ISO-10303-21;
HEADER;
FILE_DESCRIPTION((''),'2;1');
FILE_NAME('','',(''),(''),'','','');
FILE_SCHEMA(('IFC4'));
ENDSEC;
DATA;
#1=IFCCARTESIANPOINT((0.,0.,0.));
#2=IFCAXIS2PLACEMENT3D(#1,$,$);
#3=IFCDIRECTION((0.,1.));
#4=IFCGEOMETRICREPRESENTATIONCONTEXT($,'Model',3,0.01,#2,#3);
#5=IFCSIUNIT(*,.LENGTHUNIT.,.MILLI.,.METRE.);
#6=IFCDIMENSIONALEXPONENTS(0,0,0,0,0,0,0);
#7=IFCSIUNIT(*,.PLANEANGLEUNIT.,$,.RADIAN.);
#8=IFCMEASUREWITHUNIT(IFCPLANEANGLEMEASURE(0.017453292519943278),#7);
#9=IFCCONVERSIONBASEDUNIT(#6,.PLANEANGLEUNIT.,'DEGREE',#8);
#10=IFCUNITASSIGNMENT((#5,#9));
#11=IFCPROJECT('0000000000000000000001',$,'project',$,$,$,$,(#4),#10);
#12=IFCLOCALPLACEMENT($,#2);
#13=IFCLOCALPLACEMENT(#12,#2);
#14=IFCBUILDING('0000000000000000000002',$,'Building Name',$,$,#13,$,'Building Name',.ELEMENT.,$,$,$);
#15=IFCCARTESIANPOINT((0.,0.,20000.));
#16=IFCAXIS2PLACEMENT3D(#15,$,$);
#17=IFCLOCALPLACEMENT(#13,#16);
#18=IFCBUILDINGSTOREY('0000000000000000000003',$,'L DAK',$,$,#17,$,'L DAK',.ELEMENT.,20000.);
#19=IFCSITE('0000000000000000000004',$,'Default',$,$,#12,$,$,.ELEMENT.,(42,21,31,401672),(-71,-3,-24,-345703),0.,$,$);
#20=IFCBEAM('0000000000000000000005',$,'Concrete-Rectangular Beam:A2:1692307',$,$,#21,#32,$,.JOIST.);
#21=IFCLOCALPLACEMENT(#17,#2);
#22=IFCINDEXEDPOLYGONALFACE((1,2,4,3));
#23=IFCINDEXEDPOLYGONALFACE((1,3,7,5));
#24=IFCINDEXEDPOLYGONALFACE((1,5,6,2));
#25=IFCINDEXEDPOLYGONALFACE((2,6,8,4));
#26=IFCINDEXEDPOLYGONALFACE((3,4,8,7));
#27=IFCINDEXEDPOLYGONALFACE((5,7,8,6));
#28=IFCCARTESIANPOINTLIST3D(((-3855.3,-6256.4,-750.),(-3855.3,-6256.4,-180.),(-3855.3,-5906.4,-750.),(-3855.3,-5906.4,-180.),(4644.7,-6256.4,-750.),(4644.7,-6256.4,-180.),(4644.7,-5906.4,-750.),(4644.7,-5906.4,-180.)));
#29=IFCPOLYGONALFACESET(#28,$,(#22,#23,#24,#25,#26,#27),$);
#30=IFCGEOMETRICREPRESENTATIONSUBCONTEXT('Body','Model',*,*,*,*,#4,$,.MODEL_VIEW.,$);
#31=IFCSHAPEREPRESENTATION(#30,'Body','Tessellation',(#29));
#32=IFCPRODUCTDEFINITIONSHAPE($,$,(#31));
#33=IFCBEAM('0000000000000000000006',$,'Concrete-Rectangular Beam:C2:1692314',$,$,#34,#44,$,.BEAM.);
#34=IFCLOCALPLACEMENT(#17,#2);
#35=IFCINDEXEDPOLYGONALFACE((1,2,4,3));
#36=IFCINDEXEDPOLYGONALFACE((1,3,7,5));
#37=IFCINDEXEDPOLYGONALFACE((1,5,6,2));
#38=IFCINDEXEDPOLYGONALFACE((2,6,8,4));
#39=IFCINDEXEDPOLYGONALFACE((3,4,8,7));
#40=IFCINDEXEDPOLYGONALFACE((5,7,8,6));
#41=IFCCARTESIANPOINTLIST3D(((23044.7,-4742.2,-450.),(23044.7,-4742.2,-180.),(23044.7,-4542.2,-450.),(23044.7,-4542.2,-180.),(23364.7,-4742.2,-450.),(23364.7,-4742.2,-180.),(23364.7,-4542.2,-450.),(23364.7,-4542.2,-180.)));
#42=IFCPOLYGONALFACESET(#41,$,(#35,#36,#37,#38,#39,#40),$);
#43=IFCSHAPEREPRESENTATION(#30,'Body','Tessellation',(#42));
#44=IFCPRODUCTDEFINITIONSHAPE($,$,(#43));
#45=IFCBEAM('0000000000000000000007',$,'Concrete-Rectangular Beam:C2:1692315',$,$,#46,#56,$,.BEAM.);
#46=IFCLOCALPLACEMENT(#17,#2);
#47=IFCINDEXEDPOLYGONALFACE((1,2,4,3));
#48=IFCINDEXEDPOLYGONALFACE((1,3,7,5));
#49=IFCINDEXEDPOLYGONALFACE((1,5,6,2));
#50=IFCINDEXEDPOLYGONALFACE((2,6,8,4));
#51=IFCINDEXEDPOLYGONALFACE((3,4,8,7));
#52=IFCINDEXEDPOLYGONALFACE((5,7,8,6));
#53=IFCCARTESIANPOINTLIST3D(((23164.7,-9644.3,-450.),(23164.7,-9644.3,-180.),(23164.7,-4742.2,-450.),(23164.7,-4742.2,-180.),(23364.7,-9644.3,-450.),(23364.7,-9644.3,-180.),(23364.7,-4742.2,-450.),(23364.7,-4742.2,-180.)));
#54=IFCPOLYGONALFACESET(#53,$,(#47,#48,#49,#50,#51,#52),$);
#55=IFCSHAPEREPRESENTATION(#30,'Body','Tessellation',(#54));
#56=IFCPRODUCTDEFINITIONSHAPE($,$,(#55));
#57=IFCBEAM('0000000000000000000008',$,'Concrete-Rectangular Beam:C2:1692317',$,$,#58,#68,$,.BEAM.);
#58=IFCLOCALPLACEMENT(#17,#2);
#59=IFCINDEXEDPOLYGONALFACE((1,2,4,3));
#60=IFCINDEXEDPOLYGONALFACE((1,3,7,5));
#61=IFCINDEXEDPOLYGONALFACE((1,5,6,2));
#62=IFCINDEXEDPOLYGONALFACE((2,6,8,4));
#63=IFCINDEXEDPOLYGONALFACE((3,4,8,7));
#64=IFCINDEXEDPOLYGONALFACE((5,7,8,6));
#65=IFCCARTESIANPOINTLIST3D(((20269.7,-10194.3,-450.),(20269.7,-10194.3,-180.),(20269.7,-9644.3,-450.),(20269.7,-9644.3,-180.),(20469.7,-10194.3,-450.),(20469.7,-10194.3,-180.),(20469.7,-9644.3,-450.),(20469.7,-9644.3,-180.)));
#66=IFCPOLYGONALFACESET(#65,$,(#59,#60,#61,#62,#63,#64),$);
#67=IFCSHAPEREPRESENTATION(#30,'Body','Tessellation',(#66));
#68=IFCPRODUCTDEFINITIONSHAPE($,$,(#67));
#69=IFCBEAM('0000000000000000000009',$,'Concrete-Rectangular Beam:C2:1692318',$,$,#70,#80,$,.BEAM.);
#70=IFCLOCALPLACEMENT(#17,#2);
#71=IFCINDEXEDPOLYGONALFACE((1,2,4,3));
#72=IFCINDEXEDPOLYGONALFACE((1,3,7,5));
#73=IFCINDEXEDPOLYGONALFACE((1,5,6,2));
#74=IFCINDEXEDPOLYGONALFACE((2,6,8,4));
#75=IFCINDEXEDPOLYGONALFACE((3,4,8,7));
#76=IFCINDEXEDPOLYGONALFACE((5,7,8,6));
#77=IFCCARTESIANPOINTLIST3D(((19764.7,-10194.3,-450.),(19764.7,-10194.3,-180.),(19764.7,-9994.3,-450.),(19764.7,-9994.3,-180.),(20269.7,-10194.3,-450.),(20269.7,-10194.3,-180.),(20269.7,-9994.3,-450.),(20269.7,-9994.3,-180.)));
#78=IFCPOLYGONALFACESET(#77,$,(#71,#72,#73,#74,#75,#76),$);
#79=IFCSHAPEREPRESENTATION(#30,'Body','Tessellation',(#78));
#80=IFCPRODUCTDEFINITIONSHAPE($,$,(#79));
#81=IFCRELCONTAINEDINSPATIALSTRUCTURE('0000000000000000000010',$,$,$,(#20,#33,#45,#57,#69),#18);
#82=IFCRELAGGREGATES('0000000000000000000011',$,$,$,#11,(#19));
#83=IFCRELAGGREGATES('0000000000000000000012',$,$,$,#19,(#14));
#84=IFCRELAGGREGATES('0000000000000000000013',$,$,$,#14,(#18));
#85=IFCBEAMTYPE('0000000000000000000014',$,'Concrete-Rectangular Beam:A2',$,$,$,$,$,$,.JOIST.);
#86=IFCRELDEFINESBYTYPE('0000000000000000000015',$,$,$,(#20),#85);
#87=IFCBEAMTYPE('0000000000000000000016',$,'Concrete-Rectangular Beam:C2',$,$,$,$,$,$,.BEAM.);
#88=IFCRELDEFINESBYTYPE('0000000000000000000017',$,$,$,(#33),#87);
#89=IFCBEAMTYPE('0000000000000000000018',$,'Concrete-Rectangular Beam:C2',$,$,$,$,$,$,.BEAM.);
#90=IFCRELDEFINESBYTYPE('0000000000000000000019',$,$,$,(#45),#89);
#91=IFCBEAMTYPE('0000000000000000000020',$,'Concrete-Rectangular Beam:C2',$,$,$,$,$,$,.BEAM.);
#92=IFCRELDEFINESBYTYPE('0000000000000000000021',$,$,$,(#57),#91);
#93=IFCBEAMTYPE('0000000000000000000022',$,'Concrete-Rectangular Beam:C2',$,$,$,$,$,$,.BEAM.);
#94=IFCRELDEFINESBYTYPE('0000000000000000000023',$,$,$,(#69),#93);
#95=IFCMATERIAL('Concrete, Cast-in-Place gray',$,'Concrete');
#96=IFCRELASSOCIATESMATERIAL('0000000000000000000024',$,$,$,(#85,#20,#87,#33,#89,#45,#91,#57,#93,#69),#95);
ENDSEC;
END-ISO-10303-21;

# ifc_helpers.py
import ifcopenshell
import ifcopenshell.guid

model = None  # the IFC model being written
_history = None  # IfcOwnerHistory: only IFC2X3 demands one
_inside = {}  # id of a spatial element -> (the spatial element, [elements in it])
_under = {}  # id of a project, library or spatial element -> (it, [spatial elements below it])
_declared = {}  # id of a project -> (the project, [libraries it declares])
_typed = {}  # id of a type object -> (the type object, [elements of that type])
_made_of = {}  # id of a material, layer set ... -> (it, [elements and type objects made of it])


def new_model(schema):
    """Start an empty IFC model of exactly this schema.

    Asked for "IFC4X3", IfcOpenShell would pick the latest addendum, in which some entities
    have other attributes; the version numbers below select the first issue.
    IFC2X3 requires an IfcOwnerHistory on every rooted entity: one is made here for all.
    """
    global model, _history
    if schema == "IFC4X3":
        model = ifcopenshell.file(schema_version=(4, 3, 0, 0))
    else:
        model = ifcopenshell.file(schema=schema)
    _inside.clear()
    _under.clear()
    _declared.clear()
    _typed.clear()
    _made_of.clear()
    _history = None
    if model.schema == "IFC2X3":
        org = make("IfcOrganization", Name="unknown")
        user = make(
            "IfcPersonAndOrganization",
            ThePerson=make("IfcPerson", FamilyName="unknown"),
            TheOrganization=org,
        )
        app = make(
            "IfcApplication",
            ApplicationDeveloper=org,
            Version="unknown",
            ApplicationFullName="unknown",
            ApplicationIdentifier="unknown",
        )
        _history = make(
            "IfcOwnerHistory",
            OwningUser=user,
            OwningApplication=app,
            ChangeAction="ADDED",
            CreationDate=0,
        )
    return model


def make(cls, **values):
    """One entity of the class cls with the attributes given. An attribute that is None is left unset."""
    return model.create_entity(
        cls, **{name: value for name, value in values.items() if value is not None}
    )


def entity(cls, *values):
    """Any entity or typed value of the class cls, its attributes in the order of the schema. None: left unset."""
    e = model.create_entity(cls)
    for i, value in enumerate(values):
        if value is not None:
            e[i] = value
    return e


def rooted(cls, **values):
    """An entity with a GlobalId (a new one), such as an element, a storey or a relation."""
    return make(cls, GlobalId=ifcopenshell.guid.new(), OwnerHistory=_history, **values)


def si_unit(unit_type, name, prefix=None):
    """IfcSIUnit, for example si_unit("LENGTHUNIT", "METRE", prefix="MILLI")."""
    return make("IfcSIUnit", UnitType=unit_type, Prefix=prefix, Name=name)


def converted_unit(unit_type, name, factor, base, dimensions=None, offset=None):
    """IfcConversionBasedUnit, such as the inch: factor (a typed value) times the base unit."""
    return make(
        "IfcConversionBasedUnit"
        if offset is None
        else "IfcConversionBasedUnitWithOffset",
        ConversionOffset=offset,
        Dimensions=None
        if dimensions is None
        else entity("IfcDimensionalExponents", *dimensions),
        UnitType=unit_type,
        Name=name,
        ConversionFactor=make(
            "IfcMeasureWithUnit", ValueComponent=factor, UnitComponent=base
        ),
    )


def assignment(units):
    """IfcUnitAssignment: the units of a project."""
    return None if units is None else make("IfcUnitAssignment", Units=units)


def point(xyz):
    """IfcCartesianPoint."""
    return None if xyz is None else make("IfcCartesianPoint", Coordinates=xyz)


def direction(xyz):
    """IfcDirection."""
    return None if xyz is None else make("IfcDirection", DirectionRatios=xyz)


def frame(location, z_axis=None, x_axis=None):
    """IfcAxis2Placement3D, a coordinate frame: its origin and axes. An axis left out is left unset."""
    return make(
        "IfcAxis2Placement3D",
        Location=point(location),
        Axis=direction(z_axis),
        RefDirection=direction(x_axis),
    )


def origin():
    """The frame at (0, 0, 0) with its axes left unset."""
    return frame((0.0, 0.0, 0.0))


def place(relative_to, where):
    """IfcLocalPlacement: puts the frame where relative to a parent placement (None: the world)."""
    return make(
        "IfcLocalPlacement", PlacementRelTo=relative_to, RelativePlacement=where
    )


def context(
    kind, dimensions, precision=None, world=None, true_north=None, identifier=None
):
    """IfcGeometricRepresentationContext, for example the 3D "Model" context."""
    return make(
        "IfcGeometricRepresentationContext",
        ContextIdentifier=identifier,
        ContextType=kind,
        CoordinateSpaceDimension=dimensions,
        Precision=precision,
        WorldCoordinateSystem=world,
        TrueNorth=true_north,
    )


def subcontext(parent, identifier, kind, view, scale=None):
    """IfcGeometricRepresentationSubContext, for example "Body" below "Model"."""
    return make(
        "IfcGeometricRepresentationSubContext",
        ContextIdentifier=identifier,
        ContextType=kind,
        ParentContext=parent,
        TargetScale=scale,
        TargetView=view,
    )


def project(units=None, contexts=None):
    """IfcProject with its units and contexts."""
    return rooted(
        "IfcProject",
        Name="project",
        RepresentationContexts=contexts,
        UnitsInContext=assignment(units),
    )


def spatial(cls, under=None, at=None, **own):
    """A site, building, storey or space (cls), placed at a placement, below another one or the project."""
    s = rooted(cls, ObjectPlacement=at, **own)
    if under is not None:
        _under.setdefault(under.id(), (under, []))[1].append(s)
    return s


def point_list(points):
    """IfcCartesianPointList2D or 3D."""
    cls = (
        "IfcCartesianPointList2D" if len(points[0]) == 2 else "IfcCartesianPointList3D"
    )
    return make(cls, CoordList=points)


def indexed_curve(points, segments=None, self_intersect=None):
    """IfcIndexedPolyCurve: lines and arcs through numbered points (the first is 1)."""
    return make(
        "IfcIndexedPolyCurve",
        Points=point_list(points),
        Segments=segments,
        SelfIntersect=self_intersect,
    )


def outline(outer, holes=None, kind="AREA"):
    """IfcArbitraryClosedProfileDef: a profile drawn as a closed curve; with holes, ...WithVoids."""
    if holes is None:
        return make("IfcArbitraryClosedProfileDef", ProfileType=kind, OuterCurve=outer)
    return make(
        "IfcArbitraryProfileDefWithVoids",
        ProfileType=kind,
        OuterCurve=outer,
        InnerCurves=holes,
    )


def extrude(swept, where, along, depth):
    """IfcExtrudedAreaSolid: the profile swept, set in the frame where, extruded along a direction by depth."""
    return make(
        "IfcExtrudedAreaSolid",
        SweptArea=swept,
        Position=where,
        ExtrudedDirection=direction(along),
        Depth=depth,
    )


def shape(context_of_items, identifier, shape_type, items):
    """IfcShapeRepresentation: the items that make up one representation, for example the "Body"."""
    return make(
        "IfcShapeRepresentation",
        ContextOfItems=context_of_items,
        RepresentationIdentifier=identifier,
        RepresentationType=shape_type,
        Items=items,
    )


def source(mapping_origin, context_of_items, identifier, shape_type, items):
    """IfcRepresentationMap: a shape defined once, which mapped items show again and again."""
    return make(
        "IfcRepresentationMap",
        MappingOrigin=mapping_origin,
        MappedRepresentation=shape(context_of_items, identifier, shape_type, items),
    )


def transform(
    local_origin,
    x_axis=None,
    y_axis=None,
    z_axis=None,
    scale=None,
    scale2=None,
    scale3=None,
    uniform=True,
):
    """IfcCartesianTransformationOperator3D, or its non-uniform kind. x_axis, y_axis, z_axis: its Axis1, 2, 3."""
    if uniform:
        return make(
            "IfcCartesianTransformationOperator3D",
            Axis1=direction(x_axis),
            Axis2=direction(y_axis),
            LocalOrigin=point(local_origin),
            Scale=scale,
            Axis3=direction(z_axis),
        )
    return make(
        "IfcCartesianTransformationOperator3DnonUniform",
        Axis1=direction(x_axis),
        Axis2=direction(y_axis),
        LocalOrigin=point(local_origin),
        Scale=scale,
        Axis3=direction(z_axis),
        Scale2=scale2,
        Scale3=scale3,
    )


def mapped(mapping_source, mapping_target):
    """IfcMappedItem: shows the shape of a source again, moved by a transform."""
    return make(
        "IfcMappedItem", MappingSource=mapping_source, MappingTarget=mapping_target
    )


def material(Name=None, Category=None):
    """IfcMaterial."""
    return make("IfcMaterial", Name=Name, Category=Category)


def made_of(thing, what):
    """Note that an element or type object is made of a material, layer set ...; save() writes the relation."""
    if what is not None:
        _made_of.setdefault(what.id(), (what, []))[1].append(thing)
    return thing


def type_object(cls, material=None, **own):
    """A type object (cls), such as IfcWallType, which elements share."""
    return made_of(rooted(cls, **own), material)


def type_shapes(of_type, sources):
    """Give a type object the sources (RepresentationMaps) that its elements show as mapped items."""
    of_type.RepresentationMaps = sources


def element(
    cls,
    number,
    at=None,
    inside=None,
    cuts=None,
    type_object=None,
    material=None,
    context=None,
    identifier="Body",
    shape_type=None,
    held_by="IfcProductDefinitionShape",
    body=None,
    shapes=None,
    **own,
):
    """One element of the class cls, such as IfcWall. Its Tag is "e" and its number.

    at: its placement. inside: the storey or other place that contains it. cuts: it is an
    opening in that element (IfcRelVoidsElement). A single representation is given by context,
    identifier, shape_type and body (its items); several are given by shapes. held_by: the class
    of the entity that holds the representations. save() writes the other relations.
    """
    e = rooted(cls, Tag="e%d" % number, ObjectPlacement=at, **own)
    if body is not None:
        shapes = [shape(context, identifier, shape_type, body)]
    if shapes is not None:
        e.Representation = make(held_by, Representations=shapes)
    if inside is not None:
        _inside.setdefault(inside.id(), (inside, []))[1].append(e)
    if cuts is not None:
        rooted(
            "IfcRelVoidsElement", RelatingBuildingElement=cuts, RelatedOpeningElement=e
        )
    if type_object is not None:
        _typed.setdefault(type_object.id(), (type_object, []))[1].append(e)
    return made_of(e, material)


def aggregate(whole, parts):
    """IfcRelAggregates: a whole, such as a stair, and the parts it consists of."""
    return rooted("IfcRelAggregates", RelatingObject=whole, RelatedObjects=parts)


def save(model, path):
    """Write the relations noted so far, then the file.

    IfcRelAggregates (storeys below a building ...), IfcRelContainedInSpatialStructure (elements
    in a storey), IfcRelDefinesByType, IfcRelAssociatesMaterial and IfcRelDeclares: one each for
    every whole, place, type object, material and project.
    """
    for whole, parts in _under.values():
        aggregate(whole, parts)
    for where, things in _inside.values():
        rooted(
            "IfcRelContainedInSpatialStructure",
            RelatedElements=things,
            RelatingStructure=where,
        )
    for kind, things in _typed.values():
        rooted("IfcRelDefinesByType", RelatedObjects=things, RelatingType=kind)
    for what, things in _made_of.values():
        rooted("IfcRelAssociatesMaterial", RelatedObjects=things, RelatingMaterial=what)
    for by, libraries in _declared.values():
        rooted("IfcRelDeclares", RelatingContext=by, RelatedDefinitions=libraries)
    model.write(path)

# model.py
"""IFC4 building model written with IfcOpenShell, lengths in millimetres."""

from ifc_helpers import new_model, entity, si_unit, converted_unit, direction, frame, origin, place, context, subcontext, project, spatial, indexed_curve, outline, extrude, source, transform, mapped, material, type_object, type_shapes, element, save


model = new_model("IFC4")

# Units and contexts
model_context = context("Model", 3, precision=0.01, world=origin(), true_north=direction((0.0, 1.0)))
body_context = subcontext(model_context, "Body", "Model", "MODEL_VIEW")
ifc_project = project(units=[si_unit("LENGTHUNIT", "METRE", prefix="MILLI"), converted_unit("PLANEANGLEUNIT", "DEGREE", entity("IfcPlaneAngleMeasure", 0.017453292519943278), si_unit("PLANEANGLEUNIT", "RADIAN"), dimensions=[0, 0, 0, 0, 0, 0, 0])], contexts=[model_context])

# Site, building, storey
site_placement = place(None, origin())
site = spatial("IfcSite", under=ifc_project, at=site_placement, Name="Default", CompositionType="ELEMENT", RefLatitude=(42, 21, 31, 401672), RefLongitude=(-71, -3, -24, -345703), RefElevation=0.0)
building_placement = place(site_placement, origin())
building = spatial("IfcBuilding", under=site, at=building_placement, Name="Building Name", LongName="Building Name", CompositionType="ELEMENT")
storey_placement = place(building_placement, frame((0.0, 0.0, 20000.0)))
storey = spatial("IfcBuildingStorey", under=building, at=storey_placement, Name="L DAK", LongName="L DAK", CompositionType="ELEMENT", Elevation=20000.0)

# Beams
ifc_material = material(Name="Concrete, Cast-in-Place gray", Category="Concrete")
beam_type_1 = type_object("IfcBeamType", Name="Concrete-Rectangular Beam:A2", PredefinedType="JOIST", material=ifc_material)
shared_shape_1 = source(origin(), body_context, "Body", "SweptSolid", [
    extrude(outline(indexed_curve([(-285.0, -175.0), (285.0, -175.0), (285.0, 175.0), (-285.0, 175.0), (-285.0, -175.0)], self_intersect=False)), frame((-3855.3, -6081.4, 19535.0), z_axis=(1.0, 0.0, 0.0), x_axis=(0.0, 0.0, -1.0)), (0.0, 0.0, 1.0), 8500.0),
])
type_shapes(beam_type_1, [shared_shape_1])
beam_1_placement = place(storey_placement, frame((0.0, 0.0, -20000.0)))
element("IfcBeam", 1, at=beam_1_placement, inside=storey, type_object=beam_type_1, material=ifc_material, Name="Concrete-Rectangular Beam:A2:1692307", PredefinedType="JOIST", context=body_context, shape_type="MappedRepresentation", body=[
    mapped(shared_shape_1, transform((0.0, 0.0, 0.0), scale=1.0)),
])
beam_type_2 = type_object("IfcBeamType", Name="Concrete-Rectangular Beam:C2", PredefinedType="BEAM", material=ifc_material)
shared_shape_2 = source(origin(), body_context, "Body", "SweptSolid", [
    extrude(outline(indexed_curve([(-135.0, -100.0), (135.0, -100.0), (135.0, 100.0), (-135.0, 100.0), (-135.0, -100.0)], self_intersect=False)), frame((23044.7, -4642.2, 19685.0), z_axis=(1.0, 0.0, 0.0), x_axis=(0.0, 0.0, -1.0)), (0.0, 0.0, 1.0), 320.0),
])
type_shapes(beam_type_2, [shared_shape_2])
beam_2_placement = place(storey_placement, frame((0.0, 0.0, -20000.0)))
element("IfcBeam", 2, at=beam_2_placement, inside=storey, type_object=beam_type_2, material=ifc_material, Name="Concrete-Rectangular Beam:C2:1692314", PredefinedType="BEAM", context=body_context, shape_type="MappedRepresentation", body=[
    mapped(shared_shape_2, transform((0.0, 0.0, 0.0), scale=1.0)),
])
beam_type_3 = type_object("IfcBeamType", Name="Concrete-Rectangular Beam:C2", PredefinedType="BEAM", material=ifc_material)
shared_shape_3 = source(origin(), body_context, "Body", "SweptSolid", [
    extrude(outline(indexed_curve([(-100.0, -135.0), (100.0, -135.0), (100.0, 135.0), (-100.0, 135.0), (-100.0, -135.0)], self_intersect=False)), frame((23264.7, -4742.2, 19685.0), z_axis=(0.0, -1.0, 0.0), x_axis=(-1.0, 0.0, 0.0)), (0.0, 0.0, 1.0), 4902.1),
])
type_shapes(beam_type_3, [shared_shape_3])
beam_3_placement = place(storey_placement, frame((0.0, 0.0, -20000.0)))
element("IfcBeam", 3, at=beam_3_placement, inside=storey, type_object=beam_type_3, material=ifc_material, Name="Concrete-Rectangular Beam:C2:1692315", PredefinedType="BEAM", context=body_context, shape_type="MappedRepresentation", body=[
    mapped(shared_shape_3, transform((0.0, 0.0, 0.0), scale=1.0)),
])
beam_type_4 = type_object("IfcBeamType", Name="Concrete-Rectangular Beam:C2", PredefinedType="BEAM", material=ifc_material)
shared_shape_4 = source(origin(), body_context, "Body", "SweptSolid", [
    extrude(outline(indexed_curve([(-100.0, -135.0), (100.0, -135.0), (100.0, 135.0), (-100.0, 135.0), (-100.0, -135.0)], self_intersect=False)), frame((20369.7, -9644.3, 19685.0), z_axis=(0.0, -1.0, 0.0), x_axis=(-1.0, 0.0, 0.0)), (0.0, 0.0, 1.0), 550.0),
])
type_shapes(beam_type_4, [shared_shape_4])
beam_4_placement = place(storey_placement, frame((0.0, 0.0, -20000.0)))
element("IfcBeam", 4, at=beam_4_placement, inside=storey, type_object=beam_type_4, material=ifc_material, Name="Concrete-Rectangular Beam:C2:1692317", PredefinedType="BEAM", context=body_context, shape_type="MappedRepresentation", body=[
    mapped(shared_shape_4, transform((0.0, 0.0, 0.0), scale=1.0)),
])
beam_type_5 = type_object("IfcBeamType", Name="Concrete-Rectangular Beam:C2", PredefinedType="BEAM", material=ifc_material)
shared_shape_5 = source(origin(), body_context, "Body", "SweptSolid", [
    extrude(outline(indexed_curve([(-135.0, -100.0), (135.0, -100.0), (135.0, 100.0), (-135.0, 100.0), (-135.0, -100.0)], self_intersect=False)), frame((20269.7, -10094.3, 19685.0), z_axis=(-1.0, 0.0, 0.0), x_axis=(0.0, 0.0, -1.0)), (0.0, 0.0, 1.0), 505.0),
])
type_shapes(beam_type_5, [shared_shape_5])
beam_5_placement = place(storey_placement, frame((0.0, 0.0, -20000.0)))
element("IfcBeam", 5, at=beam_5_placement, inside=storey, type_object=beam_type_5, material=ifc_material, Name="Concrete-Rectangular Beam:C2:1692318", PredefinedType="BEAM", context=body_context, shape_type="MappedRepresentation", body=[
    mapped(shared_shape_5, transform((0.0, 0.0, 0.0), scale=1.0)),
])

save(model, "model.ifc")
